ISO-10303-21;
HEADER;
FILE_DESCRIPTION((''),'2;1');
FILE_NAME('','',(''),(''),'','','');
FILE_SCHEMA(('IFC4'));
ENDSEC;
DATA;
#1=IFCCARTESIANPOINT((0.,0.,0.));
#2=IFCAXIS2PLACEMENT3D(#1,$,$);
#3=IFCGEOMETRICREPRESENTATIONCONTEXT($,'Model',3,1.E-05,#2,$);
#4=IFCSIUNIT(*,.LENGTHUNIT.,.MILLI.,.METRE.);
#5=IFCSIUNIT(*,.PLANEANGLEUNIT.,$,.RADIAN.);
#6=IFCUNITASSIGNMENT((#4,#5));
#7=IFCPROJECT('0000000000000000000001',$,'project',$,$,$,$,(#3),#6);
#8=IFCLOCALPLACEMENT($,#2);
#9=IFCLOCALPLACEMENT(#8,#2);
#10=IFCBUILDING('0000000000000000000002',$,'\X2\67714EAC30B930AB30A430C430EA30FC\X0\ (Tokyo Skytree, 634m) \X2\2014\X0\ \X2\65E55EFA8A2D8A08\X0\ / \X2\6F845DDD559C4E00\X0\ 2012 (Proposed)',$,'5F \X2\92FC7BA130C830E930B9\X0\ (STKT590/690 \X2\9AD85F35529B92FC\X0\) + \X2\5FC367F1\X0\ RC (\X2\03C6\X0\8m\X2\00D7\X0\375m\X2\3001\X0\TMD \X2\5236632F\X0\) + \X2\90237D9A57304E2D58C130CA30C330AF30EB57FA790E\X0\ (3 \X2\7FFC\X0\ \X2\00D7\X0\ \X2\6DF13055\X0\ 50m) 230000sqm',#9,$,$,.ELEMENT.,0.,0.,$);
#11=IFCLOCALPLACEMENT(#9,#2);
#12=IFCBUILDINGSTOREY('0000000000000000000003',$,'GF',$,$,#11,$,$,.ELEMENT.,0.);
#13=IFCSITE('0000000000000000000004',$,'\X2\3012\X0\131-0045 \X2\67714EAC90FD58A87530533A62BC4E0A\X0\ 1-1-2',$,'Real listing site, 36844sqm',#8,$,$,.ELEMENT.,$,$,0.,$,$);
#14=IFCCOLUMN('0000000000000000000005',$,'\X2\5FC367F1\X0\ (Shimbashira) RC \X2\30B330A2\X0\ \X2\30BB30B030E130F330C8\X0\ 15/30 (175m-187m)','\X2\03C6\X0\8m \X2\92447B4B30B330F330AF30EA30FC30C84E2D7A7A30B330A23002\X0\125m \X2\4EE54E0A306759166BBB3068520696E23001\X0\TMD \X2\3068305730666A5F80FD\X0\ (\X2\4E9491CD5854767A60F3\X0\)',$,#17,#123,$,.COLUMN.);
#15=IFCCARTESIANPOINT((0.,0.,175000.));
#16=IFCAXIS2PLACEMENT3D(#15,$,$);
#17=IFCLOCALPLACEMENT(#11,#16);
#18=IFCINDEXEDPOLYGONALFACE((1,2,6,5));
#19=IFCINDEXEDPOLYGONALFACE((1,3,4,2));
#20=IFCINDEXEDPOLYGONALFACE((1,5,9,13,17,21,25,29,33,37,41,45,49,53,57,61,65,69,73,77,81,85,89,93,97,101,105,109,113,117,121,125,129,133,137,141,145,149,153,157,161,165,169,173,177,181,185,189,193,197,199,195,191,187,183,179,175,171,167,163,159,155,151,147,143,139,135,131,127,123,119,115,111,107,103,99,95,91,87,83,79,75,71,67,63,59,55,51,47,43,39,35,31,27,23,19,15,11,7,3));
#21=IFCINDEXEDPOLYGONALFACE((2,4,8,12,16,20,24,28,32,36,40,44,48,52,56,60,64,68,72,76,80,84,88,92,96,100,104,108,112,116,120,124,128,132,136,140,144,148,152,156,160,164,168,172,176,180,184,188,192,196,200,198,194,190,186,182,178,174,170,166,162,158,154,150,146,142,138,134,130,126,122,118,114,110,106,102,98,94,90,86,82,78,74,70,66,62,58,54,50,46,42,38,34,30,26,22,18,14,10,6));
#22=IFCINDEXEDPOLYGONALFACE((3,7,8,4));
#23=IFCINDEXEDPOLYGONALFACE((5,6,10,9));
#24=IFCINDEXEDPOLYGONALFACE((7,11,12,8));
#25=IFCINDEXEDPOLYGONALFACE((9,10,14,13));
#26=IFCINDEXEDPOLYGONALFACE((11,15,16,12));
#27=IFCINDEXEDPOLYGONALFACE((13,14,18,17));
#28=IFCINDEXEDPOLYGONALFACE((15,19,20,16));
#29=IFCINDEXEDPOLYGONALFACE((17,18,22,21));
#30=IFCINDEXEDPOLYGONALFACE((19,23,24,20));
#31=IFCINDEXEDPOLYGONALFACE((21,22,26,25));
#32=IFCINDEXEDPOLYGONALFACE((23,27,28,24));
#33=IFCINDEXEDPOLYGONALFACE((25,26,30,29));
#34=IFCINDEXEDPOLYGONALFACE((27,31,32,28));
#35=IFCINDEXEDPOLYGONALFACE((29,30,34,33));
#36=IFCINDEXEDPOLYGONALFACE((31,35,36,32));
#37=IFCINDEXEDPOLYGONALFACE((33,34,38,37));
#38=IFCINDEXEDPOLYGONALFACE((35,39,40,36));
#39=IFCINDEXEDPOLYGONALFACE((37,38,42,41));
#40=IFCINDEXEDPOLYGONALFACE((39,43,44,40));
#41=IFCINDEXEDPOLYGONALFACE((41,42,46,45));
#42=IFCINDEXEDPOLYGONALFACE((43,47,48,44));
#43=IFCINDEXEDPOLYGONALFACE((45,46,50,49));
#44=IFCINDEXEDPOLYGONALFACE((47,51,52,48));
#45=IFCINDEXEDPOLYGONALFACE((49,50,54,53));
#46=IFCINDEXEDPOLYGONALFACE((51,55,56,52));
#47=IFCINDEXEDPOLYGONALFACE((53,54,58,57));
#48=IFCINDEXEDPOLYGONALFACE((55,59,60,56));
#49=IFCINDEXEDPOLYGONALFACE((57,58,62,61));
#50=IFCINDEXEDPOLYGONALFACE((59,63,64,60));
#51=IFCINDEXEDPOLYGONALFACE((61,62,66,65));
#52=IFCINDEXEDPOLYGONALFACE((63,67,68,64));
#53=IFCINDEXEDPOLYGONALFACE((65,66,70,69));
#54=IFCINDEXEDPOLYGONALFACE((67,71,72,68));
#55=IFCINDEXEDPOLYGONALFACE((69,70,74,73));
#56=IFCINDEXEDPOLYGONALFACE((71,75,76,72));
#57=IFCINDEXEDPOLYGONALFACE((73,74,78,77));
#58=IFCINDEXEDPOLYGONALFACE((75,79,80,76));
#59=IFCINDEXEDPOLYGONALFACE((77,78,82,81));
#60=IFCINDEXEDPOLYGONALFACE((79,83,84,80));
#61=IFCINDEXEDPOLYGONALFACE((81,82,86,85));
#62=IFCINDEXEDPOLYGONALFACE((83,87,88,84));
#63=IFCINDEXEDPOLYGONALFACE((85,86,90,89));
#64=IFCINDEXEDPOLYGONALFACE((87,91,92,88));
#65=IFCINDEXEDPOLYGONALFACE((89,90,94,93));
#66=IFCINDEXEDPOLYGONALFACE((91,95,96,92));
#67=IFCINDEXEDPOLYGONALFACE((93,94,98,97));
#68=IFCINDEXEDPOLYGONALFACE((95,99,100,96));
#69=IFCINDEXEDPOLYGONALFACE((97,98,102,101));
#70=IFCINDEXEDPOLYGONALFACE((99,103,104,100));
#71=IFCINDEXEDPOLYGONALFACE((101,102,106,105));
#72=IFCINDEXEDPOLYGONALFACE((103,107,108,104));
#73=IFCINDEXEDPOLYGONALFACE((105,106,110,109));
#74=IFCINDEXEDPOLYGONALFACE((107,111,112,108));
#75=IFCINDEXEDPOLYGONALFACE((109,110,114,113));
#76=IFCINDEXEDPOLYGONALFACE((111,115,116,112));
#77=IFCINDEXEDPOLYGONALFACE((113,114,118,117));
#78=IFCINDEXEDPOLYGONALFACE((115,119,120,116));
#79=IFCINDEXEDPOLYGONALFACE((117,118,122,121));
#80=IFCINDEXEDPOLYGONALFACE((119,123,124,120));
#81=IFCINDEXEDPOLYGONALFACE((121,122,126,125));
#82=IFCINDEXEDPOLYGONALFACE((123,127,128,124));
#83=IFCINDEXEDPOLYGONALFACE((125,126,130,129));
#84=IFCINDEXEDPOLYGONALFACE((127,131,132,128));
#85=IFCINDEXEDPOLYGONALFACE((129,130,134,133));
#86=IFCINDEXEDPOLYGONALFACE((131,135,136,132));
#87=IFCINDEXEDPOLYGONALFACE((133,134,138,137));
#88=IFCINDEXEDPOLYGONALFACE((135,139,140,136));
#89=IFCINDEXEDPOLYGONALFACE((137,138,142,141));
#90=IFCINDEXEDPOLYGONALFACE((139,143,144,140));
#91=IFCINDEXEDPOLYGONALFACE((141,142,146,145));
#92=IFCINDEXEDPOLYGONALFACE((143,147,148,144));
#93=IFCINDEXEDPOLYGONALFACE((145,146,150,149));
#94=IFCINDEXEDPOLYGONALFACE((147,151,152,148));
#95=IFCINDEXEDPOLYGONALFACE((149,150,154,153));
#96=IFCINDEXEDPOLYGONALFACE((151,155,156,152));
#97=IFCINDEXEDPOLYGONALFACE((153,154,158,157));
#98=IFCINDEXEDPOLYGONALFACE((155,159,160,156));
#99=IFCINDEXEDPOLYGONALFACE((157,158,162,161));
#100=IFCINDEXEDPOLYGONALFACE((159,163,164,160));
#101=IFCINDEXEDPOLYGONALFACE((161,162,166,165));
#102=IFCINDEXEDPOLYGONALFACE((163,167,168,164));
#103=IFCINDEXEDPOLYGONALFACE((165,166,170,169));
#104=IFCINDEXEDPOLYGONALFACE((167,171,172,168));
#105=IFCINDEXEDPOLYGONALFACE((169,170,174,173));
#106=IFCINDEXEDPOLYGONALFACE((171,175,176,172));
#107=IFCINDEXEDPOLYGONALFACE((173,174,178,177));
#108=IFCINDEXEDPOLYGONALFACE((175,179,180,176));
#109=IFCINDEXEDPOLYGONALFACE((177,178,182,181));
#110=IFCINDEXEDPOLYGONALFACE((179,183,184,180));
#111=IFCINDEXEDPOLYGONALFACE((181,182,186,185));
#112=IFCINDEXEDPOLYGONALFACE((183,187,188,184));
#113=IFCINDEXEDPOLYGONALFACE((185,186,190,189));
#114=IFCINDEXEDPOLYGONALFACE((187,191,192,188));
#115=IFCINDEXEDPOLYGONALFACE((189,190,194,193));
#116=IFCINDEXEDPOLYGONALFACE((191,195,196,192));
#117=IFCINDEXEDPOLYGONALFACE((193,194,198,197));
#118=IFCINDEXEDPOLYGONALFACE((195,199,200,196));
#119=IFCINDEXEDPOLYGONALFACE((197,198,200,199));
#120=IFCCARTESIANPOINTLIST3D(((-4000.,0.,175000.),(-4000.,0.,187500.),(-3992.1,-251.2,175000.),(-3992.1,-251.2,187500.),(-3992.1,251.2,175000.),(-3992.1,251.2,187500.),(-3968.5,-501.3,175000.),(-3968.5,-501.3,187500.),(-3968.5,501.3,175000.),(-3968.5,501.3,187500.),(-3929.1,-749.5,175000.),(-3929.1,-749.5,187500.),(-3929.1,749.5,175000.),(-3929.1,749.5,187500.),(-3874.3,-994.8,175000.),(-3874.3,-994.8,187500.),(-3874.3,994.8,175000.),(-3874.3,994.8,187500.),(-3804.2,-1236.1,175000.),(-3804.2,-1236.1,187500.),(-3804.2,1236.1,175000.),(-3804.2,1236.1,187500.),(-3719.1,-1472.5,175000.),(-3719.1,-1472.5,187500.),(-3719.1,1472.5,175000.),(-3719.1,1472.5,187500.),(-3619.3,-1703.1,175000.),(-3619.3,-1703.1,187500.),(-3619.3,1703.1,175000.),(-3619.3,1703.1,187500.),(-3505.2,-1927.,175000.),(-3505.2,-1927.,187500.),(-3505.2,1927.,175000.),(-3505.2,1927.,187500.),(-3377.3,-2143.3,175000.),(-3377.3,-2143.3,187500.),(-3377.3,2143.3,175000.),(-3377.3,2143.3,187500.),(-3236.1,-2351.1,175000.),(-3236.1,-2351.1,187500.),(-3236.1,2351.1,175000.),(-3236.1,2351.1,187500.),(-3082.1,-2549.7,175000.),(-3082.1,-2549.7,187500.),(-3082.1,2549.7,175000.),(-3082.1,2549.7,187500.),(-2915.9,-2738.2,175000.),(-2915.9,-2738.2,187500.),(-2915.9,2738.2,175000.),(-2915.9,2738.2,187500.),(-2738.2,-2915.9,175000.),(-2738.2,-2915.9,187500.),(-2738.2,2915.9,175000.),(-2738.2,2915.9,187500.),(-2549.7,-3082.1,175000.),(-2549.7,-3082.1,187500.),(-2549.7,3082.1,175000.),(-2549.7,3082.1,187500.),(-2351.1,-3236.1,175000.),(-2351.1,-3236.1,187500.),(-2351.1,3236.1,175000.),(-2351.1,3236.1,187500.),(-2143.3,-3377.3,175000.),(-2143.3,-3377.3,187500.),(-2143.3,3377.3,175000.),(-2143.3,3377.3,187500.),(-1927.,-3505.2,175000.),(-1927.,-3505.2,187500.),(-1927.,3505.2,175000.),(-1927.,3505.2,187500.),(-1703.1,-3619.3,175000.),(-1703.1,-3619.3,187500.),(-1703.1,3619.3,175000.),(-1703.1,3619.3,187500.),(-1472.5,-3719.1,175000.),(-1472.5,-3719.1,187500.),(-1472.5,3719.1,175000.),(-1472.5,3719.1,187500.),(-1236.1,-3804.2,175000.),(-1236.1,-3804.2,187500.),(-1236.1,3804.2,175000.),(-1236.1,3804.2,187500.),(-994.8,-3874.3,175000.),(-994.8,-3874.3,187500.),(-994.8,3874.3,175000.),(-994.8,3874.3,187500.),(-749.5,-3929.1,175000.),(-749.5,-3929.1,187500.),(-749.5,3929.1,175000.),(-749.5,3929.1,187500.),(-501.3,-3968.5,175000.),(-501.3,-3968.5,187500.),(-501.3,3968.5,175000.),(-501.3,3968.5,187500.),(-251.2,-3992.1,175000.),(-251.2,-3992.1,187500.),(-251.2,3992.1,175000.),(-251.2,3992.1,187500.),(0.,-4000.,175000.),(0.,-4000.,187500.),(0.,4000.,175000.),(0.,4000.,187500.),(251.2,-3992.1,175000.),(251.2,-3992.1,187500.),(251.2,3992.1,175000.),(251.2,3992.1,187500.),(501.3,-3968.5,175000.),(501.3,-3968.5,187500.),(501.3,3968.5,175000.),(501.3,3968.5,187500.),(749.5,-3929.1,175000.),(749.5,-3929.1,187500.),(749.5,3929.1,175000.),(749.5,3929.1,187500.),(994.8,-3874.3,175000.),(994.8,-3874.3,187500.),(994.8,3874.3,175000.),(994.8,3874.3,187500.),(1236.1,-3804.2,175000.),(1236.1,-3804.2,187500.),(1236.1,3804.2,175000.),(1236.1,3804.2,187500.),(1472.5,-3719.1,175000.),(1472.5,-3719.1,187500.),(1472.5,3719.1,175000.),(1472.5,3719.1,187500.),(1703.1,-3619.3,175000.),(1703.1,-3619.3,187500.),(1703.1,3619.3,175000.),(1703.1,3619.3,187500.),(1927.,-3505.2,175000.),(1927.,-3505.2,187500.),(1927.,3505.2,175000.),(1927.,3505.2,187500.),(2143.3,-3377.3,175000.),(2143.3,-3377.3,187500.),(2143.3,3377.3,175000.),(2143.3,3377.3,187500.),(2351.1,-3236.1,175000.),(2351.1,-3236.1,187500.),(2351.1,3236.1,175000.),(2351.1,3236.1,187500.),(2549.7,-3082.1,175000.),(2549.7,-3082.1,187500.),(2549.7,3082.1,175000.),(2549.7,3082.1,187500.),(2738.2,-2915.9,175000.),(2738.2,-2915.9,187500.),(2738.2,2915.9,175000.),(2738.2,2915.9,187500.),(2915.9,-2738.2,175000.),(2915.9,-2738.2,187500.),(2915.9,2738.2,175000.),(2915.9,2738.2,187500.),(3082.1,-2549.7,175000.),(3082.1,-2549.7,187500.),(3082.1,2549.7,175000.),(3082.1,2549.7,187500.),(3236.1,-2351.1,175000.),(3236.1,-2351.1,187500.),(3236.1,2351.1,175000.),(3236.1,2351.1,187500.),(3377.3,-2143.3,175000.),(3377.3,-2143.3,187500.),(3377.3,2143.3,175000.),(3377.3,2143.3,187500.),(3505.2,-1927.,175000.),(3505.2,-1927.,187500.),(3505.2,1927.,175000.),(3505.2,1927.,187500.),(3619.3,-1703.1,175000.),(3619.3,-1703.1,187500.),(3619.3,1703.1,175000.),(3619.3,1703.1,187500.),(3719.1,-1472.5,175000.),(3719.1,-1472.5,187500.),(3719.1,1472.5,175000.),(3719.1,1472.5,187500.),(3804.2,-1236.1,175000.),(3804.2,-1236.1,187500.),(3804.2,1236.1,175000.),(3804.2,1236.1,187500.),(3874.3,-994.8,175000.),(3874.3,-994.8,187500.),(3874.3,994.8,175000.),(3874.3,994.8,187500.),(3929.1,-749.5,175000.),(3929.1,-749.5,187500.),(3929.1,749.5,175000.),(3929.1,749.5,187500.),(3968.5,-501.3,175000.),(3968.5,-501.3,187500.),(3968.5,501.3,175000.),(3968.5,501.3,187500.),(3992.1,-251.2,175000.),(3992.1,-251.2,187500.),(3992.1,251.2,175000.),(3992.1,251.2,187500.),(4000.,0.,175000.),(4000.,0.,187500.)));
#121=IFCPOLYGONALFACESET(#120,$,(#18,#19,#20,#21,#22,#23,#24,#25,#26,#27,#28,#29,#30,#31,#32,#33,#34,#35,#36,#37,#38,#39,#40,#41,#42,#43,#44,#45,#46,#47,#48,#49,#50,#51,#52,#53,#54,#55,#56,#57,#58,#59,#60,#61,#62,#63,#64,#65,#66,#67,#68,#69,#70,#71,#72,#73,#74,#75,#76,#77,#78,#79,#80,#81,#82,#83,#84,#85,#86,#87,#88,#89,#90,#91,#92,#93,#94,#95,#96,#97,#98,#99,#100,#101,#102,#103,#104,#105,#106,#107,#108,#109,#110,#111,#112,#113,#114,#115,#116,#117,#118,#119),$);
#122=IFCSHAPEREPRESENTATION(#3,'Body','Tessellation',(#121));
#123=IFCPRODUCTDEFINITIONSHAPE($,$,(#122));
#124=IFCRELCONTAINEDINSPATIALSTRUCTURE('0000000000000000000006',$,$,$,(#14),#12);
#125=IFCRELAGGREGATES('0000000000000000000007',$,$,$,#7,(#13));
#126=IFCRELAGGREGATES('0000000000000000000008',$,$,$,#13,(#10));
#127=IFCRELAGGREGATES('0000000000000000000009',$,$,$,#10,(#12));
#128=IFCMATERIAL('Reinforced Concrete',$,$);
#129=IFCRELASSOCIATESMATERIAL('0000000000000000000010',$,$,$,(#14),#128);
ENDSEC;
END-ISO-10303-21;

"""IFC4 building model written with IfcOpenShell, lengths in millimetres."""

from ifc_helpers import new_model, si_unit, frame, origin, origin_2d, place, context, project, spatial, circle, extrude, material, element, save


model = new_model("IFC4")

# Units and contexts
model_context = context("Model", 3, precision=1e-05, world=origin())
ifc_project = project(units=[si_unit("LENGTHUNIT", "METRE", prefix="MILLI"), si_unit("PLANEANGLEUNIT", "RADIAN")], contexts=[model_context])

# Site, building, storey
site_placement = place(None, origin())
site = spatial("IfcSite", under=ifc_project, at=site_placement, Name="〒131-0045 東京都墨田区押上 1-1-2", ObjectType="Real listing site, 36844sqm", CompositionType="ELEMENT", RefElevation=0.0)
building_placement = place(site_placement, origin())
building = spatial("IfcBuilding", under=site, at=building_placement, Name="東京スカイツリー (Tokyo Skytree, 634m) — 日建設計 / 澄川喜一 2012 (Proposed)", ObjectType="5F 鋼管トラス (STKT590/690 高張力鋼) + 心柱 RC (φ8m×375m、TMD 制振) + 連続地中壁ナックル基礎 (3 翼 × 深さ 50m) 230000sqm", CompositionType="ELEMENT", ElevationOfRefHeight=0.0, ElevationOfTerrain=0.0)
storey_placement = place(building_placement, origin())
storey = spatial("IfcBuildingStorey", under=building, at=storey_placement, Name="GF", CompositionType="ELEMENT", Elevation=0.0)

# Column
ifc_material_1 = material(Name="Reinforced Concrete")
column_1_placement = place(storey_placement, frame((0.0, 0.0, 175000.0)))
element("IfcColumn", 1, at=column_1_placement, inside=storey, material=ifc_material_1, Name="心柱 (Shimbashira) RC コア セグメント 15/30 (175m-187m)", Description="φ8m 鉄筋コンクリート中空コア。125m 以上で外殻と分離、TMD として機能 (五重塔発想)", PredefinedType="COLUMN", context=model_context, shape_type="SweptSolid", body=[
    extrude(circle(Radius=4000.0, at=origin_2d()), frame((0.0, 0.0, 175000.0)), (0.0, 0.0, 1.0), 12500.0),
])

save(model, "model.ifc")
